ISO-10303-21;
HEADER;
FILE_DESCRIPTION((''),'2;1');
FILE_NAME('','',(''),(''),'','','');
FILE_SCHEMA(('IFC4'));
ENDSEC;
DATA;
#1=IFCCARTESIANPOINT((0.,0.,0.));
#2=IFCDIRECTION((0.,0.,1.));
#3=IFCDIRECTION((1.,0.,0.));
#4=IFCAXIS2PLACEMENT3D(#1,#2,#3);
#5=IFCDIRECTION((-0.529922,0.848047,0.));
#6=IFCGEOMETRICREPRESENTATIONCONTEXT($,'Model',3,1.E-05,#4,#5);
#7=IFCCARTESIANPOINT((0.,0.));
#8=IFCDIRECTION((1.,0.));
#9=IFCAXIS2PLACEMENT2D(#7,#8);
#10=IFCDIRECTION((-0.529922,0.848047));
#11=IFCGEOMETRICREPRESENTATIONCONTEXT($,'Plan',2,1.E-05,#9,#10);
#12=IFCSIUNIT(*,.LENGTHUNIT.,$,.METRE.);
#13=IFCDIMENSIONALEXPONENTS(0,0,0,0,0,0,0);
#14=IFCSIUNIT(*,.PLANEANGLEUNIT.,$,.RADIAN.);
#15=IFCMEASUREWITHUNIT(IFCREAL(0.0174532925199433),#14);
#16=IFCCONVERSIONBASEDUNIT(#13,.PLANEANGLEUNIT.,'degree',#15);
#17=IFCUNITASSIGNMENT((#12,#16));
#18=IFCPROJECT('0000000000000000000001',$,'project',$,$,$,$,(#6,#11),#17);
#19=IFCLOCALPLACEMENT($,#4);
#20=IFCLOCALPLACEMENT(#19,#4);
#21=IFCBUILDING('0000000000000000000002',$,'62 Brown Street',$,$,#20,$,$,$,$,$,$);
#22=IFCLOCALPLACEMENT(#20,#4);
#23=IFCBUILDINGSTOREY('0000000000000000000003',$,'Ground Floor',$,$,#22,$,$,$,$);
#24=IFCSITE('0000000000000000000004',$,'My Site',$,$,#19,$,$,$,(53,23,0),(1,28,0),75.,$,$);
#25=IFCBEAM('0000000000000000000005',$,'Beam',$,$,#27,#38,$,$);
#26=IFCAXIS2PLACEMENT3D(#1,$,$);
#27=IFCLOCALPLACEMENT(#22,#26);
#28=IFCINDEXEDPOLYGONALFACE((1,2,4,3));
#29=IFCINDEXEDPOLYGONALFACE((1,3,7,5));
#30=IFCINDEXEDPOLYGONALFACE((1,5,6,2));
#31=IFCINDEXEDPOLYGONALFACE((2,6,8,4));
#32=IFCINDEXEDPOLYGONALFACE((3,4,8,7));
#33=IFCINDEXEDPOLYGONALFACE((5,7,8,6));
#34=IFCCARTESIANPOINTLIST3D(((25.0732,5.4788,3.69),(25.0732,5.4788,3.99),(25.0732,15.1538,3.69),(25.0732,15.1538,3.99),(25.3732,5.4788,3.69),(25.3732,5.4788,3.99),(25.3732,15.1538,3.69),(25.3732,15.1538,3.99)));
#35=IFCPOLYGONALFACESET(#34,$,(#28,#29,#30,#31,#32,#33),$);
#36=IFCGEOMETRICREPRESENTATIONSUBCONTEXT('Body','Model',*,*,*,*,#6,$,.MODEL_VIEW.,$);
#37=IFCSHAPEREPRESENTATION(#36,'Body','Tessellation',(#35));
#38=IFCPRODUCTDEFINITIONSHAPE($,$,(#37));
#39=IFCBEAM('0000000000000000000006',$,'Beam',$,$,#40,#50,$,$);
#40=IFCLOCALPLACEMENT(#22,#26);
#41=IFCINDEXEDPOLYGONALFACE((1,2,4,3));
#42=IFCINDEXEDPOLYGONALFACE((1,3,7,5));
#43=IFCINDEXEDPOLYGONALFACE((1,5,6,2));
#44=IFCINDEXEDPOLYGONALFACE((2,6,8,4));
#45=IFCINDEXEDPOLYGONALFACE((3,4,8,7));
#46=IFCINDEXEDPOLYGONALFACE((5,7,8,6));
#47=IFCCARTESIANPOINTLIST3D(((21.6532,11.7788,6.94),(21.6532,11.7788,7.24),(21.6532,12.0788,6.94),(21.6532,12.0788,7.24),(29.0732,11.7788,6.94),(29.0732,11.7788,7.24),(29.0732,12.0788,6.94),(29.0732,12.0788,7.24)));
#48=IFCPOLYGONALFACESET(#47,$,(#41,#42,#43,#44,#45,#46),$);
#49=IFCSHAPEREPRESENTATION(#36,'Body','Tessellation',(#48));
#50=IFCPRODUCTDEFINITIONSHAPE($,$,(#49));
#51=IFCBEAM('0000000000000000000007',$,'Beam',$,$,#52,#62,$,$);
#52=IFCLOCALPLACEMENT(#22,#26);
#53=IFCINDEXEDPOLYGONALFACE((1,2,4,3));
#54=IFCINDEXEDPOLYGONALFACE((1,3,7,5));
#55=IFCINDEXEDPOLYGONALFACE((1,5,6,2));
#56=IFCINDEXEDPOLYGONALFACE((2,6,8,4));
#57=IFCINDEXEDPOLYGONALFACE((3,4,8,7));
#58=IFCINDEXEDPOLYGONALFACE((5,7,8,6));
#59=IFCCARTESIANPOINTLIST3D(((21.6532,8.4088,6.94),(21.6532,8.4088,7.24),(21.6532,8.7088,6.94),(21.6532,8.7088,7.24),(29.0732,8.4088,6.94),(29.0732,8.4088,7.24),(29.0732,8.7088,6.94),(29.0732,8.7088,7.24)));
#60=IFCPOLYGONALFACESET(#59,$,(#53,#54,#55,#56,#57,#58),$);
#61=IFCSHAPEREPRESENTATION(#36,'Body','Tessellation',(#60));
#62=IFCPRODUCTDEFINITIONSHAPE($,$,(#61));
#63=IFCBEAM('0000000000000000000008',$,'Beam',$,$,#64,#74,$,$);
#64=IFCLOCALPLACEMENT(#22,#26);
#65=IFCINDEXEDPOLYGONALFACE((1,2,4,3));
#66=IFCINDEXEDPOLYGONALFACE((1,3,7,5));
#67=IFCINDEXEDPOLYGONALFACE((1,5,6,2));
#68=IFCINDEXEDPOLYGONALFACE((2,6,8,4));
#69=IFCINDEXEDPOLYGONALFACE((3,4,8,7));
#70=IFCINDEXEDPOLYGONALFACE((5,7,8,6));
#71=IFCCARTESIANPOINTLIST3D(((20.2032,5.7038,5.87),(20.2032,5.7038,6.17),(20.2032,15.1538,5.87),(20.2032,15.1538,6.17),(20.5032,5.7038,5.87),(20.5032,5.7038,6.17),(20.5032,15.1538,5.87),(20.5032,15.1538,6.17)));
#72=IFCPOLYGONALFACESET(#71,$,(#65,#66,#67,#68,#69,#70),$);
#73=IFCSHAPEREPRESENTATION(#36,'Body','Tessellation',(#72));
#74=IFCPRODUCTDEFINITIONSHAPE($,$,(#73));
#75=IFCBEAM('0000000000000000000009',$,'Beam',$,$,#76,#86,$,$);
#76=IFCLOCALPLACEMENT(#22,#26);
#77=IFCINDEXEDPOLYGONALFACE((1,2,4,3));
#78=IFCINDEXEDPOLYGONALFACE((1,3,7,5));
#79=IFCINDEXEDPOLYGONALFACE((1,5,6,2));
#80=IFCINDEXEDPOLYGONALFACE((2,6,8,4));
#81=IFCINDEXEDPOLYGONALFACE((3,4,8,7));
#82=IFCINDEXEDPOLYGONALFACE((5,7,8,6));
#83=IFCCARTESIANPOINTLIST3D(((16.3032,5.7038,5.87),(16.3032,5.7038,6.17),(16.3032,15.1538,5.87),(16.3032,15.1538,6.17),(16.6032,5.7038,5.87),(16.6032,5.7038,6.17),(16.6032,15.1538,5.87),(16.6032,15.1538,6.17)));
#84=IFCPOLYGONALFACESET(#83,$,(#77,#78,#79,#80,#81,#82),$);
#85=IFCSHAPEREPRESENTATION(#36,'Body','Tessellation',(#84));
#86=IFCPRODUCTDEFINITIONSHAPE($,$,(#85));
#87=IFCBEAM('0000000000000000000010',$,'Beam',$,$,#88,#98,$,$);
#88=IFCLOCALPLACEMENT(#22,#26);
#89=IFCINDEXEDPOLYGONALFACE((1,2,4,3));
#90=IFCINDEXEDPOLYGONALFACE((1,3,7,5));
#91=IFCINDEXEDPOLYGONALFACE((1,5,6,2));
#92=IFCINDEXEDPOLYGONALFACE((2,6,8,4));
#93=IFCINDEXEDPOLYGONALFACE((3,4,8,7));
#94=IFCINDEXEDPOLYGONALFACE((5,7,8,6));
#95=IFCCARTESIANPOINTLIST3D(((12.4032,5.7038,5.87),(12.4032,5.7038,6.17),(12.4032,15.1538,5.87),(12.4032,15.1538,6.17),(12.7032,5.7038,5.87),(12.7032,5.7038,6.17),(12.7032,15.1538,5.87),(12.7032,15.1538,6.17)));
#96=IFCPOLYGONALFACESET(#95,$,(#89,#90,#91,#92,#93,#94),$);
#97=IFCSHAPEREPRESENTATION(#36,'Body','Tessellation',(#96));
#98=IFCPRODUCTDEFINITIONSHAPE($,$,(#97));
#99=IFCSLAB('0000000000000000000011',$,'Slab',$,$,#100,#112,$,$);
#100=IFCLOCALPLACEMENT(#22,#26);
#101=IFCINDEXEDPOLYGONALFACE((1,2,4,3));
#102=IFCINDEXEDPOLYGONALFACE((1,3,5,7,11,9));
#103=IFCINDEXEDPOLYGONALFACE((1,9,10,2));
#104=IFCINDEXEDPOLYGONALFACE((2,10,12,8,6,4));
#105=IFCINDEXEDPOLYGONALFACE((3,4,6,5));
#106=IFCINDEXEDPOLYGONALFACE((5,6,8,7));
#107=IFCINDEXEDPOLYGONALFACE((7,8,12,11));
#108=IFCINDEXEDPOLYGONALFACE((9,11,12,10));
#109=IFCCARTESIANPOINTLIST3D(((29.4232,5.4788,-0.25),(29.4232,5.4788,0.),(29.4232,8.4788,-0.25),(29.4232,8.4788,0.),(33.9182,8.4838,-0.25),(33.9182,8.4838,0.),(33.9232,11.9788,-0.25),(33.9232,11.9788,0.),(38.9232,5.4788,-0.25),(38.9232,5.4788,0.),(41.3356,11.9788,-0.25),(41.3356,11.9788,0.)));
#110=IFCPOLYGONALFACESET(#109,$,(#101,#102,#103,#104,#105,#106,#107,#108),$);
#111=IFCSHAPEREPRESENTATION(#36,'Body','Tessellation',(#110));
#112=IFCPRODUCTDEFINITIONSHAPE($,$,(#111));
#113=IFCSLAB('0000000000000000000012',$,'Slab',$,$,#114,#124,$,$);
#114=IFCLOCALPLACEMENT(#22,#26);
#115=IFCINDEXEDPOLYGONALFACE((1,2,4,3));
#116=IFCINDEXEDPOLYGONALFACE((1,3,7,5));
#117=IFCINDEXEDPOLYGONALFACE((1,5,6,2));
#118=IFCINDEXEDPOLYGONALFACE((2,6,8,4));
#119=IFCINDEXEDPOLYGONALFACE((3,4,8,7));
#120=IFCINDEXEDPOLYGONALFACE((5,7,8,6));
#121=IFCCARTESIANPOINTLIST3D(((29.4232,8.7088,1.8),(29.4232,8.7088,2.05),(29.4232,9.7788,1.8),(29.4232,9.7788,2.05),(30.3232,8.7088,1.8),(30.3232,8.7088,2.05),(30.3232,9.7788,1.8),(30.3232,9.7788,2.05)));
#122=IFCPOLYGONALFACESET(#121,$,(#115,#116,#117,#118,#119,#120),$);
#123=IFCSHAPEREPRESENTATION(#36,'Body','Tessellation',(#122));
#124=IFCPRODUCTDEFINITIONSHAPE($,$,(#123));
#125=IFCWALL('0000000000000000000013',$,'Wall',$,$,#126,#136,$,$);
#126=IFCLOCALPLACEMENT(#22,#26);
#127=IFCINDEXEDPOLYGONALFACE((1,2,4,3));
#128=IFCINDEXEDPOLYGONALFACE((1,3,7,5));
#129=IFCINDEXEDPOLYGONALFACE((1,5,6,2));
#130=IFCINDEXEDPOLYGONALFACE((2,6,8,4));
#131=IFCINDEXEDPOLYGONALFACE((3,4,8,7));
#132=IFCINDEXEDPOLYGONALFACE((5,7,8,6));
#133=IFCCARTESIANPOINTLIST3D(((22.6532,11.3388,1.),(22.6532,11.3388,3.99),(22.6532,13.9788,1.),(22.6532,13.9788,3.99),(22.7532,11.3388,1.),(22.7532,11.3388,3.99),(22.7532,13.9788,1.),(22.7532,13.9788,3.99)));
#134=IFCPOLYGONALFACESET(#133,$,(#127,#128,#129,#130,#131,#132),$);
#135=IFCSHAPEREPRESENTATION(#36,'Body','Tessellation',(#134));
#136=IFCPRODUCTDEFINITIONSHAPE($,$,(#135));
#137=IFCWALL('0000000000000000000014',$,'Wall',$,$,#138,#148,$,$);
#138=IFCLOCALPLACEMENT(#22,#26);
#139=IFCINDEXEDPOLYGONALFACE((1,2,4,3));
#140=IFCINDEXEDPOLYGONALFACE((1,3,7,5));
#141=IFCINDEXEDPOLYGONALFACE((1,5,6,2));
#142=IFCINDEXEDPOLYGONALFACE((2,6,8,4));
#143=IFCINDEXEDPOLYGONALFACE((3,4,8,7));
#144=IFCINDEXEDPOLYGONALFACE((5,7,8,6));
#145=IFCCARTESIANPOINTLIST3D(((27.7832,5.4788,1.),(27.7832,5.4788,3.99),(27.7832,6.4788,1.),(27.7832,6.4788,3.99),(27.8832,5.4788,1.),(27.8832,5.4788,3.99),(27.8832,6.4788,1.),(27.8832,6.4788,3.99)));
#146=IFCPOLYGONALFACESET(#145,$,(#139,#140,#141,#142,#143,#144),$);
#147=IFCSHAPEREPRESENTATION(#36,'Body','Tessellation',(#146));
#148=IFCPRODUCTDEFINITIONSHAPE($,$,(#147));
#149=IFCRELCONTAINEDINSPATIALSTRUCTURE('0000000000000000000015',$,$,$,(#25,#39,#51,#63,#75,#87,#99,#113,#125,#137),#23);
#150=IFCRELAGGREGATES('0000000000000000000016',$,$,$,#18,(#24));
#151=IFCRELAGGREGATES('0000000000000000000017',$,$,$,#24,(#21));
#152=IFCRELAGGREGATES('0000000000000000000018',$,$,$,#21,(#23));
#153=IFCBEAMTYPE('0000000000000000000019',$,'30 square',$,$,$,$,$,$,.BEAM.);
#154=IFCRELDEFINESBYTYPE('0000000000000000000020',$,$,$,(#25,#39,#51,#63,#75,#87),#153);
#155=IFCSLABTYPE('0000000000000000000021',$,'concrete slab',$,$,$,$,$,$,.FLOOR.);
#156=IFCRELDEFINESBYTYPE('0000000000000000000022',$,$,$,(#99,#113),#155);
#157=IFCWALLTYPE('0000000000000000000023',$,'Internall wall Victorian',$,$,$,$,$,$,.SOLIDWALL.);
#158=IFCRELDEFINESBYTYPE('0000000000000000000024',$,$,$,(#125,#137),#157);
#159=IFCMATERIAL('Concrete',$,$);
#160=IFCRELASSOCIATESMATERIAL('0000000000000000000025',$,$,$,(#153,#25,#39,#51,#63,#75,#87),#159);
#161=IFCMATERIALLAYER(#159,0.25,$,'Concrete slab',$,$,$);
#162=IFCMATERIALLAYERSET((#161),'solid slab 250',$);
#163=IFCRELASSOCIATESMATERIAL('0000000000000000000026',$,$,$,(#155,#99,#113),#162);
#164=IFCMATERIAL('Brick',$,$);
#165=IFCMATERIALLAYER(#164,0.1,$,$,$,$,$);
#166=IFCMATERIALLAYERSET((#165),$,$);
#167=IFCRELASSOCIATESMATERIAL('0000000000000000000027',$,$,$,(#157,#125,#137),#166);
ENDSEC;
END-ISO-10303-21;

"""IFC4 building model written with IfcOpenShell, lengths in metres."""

from ifc_helpers import new_model, entity, si_unit, converted_unit, direction, frame, origin_with_axes, origin_2d_with_axis, place, context, subcontext, project, spatial, line, indexed_curve, rectangle, outline, extrude, material, layer, layer_set, layer_usage, material_profile, profile_set, profile_usage, type_object, element, save


model = new_model("IFC4")

# Units and contexts
model_context = context("Model", 3, precision=1e-05, world=origin_with_axes(), true_north=direction((-0.529922, 0.848047, 0.0)))
plan_context = context("Plan", 2, precision=1e-05, world=origin_2d_with_axis(), true_north=direction((-0.529922, 0.848047)))
body_context_1 = subcontext(model_context, "Body", "Model", "MODEL_VIEW")
ifc_project = project(units=[si_unit("LENGTHUNIT", "METRE"), converted_unit("PLANEANGLEUNIT", "degree", entity("IfcReal", 0.0174532925199433), si_unit("PLANEANGLEUNIT", "RADIAN"), dimensions=[0, 0, 0, 0, 0, 0, 0])], contexts=[model_context, plan_context])

# Site, building, storey
site_placement = place(None, origin_with_axes())
site = spatial("IfcSite", under=ifc_project, at=site_placement, Name="My Site", RefLatitude=(53, 23, 0), RefLongitude=(1, 28, 0), RefElevation=75.0)
building_placement = place(site_placement, origin_with_axes())
building = spatial("IfcBuilding", under=site, at=building_placement, Name="62 Brown Street")
storey_placement = place(building_placement, origin_with_axes())
storey = spatial("IfcBuildingStorey", under=building, at=storey_placement, Name="Ground Floor")

# Shared definitions
ifc_material_1 = material(Name="Concrete")

# Beams
ifc_material_profile_1 = material_profile(ifc_material_1, rectangle(XDim=0.3, YDim=0.3))
ifc_profile_set_1 = profile_set([ifc_material_profile_1])
ifc_profile_usage_1 = profile_usage(ifc_profile_set_1, cardinal=5)
beam_type = type_object("IfcBeamType", Name="30 square", PredefinedType="BEAM", material=ifc_profile_set_1)
beam_1_placement = place(storey_placement, frame((25.2232, 5.4788, 3.84), z_axis=(0.0, 1.0, 0.0), x_axis=(-1.0, 0.0, 0.0)))
element("IfcBeam", 1, at=beam_1_placement, inside=storey, type_object=beam_type, material=ifc_profile_usage_1, Name="Beam", context=body_context_1, shape_type="SweptSolid", body=[
    extrude(rectangle(XDim=0.3, YDim=0.3), origin_with_axes(), (0.0, 0.0, 1.0), 9.675),
])
ifc_profile_usage_2 = profile_usage(ifc_profile_set_1, cardinal=5)
beam_2_placement = place(storey_placement, frame((29.0732, 11.9288, 7.09), z_axis=(-1.0, 0.0, 0.0), x_axis=(0.0, -1.0, 0.0)))
element("IfcBeam", 2, at=beam_2_placement, inside=storey, type_object=beam_type, material=ifc_profile_usage_2, Name="Beam", context=body_context_1, shape_type="SweptSolid", body=[
    extrude(rectangle(XDim=0.3, YDim=0.3), origin_with_axes(), (0.0, 0.0, 1.0), 7.42),
])
ifc_profile_usage_3 = profile_usage(ifc_profile_set_1, cardinal=5)
beam_3_placement = place(storey_placement, frame((29.0732, 8.5588, 7.09), z_axis=(-1.0, 0.0, 0.0), x_axis=(0.0, -1.0, 0.0)))
element("IfcBeam", 3, at=beam_3_placement, inside=storey, type_object=beam_type, material=ifc_profile_usage_3, Name="Beam", context=body_context_1, shape_type="SweptSolid", body=[
    extrude(rectangle(XDim=0.3, YDim=0.3), origin_with_axes(), (0.0, 0.0, 1.0), 7.42),
])
ifc_profile_usage_4 = profile_usage(ifc_profile_set_1, cardinal=5)
beam_4_placement = place(storey_placement, frame((20.3532, 15.1538, 6.02), z_axis=(0.0, -1.0, 0.0), x_axis=(1.0, 0.0, 0.0)))
element("IfcBeam", 4, at=beam_4_placement, inside=storey, type_object=beam_type, material=ifc_profile_usage_4, Name="Beam", context=body_context_1, shape_type="SweptSolid", body=[
    extrude(rectangle(XDim=0.3, YDim=0.3), origin_with_axes(), (0.0, 0.0, 1.0), 9.45),
])
ifc_profile_usage_5 = profile_usage(ifc_profile_set_1, cardinal=5)
beam_5_placement = place(storey_placement, frame((16.4532, 15.1538, 6.02), z_axis=(0.0, -1.0, 0.0), x_axis=(1.0, 0.0, 0.0)))
element("IfcBeam", 5, at=beam_5_placement, inside=storey, type_object=beam_type, material=ifc_profile_usage_5, Name="Beam", context=body_context_1, shape_type="SweptSolid", body=[
    extrude(rectangle(XDim=0.3, YDim=0.3), origin_with_axes(), (0.0, 0.0, 1.0), 9.45),
])
ifc_profile_usage_6 = profile_usage(ifc_profile_set_1, cardinal=5)
beam_6_placement = place(storey_placement, frame((12.5532, 15.1538, 6.02), z_axis=(0.0, -1.0, 0.0), x_axis=(1.0, 0.0, 0.0)))
element("IfcBeam", 6, at=beam_6_placement, inside=storey, type_object=beam_type, material=ifc_profile_usage_6, Name="Beam", context=body_context_1, shape_type="SweptSolid", body=[
    extrude(rectangle(XDim=0.3, YDim=0.3), origin_with_axes(), (0.0, 0.0, 1.0), 9.45),
])

# Slabs
ifc_layer_1 = layer(ifc_material_1, 0.25, Name="Concrete slab")
ifc_layer_set_1 = layer_set([ifc_layer_1], Name="solid slab 250")
ifc_layer_usage_1 = layer_usage(ifc_layer_set_1, "AXIS3", "POSITIVE", 0.0)
slab_type = type_object("IfcSlabType", Name="concrete slab", PredefinedType="FLOOR", material=ifc_layer_set_1)
slab_1_placement = place(storey_placement, frame((29.4232, 5.4788, -0.25), z_axis=(0.0, 0.0, 1.0), x_axis=(1.0, 0.0, 0.0)))
element("IfcSlab", 7, at=slab_1_placement, inside=storey, type_object=slab_type, material=ifc_layer_usage_1, Name="Slab", context=body_context_1, shape_type="SweptSolid", body=[
    extrude(outline(indexed_curve([(0.0, 0.0), (9.5, 0.0), (11.9124, 6.5), (0.0, 3.0), (4.5, 6.5), (4.495, 3.005)], segments=[line(1, 2), line(2, 3), line(3, 5), line(5, 6), line(6, 4), line(4, 1)], self_intersect=False)), None, (0.0, 0.0, 1.0), 0.25),
])
ifc_layer_usage_2 = layer_usage(ifc_layer_set_1, "AXIS3", "POSITIVE", 0.0)
slab_2_placement = place(storey_placement, frame((29.4232, 8.7088, 1.8), z_axis=(0.0, 0.0, 1.0), x_axis=(1.0, 0.0, 0.0)))
element("IfcSlab", 8, at=slab_2_placement, inside=storey, type_object=slab_type, material=ifc_layer_usage_2, Name="Slab", context=body_context_1, shape_type="SweptSolid", body=[
    extrude(outline(indexed_curve([(0.9, 1.07), (0.9, 0.0), (0.0, 0.0), (0.0, 1.07)], segments=[line(3, 2), line(2, 1), line(1, 4), line(4, 3)], self_intersect=False)), None, (0.0, 0.0, 1.0), 0.25),
])

# Walls
ifc_material_2 = material(Name="Brick")
ifc_layer_2 = layer(ifc_material_2, 0.1)
ifc_layer_set_2 = layer_set([ifc_layer_2])
ifc_layer_usage_3 = layer_usage(ifc_layer_set_2, "AXIS2", "POSITIVE", 0.0)
wall_type_1 = type_object("IfcWallType", Name="Internall wall Victorian", PredefinedType="SOLIDWALL", material=ifc_layer_set_2)
wall_1_placement = place(storey_placement, frame((22.7532, 11.3388, 1.0), z_axis=(0.0, 0.0, 1.0), x_axis=(0.0, 1.0, 0.0)))
element("IfcWall", 9, at=wall_1_placement, inside=storey, type_object=wall_type_1, material=ifc_layer_usage_3, Name="Wall", context=body_context_1, shape_type="SweptSolid", body=[
    extrude(outline(indexed_curve([(0.0, 0.0), (0.0, 0.1), (2.64, 0.1), (2.64, 0.0), (0.0, 0.0)], self_intersect=False)), origin_with_axes(), (0.0, 0.0, 1.0), 2.99),
])
ifc_layer_usage_4 = layer_usage(ifc_layer_set_2, "AXIS2", "POSITIVE", 0.0)
wall_2_placement = place(storey_placement, frame((27.8832, 5.4788, 1.0), z_axis=(0.0, 0.0, 1.0), x_axis=(0.0, 1.0, 0.0)))
element("IfcWall", 10, at=wall_2_placement, inside=storey, type_object=wall_type_1, material=ifc_layer_usage_4, Name="Wall", context=body_context_1, shape_type="SweptSolid", body=[
    extrude(outline(indexed_curve([(0.0, 0.0), (0.0, 0.1), (1.0, 0.1), (1.0, 0.0), (0.0, 0.0)], self_intersect=False)), origin_with_axes(), (0.0, 0.0, 1.0), 2.99),
])

save(model, "model.ifc")
